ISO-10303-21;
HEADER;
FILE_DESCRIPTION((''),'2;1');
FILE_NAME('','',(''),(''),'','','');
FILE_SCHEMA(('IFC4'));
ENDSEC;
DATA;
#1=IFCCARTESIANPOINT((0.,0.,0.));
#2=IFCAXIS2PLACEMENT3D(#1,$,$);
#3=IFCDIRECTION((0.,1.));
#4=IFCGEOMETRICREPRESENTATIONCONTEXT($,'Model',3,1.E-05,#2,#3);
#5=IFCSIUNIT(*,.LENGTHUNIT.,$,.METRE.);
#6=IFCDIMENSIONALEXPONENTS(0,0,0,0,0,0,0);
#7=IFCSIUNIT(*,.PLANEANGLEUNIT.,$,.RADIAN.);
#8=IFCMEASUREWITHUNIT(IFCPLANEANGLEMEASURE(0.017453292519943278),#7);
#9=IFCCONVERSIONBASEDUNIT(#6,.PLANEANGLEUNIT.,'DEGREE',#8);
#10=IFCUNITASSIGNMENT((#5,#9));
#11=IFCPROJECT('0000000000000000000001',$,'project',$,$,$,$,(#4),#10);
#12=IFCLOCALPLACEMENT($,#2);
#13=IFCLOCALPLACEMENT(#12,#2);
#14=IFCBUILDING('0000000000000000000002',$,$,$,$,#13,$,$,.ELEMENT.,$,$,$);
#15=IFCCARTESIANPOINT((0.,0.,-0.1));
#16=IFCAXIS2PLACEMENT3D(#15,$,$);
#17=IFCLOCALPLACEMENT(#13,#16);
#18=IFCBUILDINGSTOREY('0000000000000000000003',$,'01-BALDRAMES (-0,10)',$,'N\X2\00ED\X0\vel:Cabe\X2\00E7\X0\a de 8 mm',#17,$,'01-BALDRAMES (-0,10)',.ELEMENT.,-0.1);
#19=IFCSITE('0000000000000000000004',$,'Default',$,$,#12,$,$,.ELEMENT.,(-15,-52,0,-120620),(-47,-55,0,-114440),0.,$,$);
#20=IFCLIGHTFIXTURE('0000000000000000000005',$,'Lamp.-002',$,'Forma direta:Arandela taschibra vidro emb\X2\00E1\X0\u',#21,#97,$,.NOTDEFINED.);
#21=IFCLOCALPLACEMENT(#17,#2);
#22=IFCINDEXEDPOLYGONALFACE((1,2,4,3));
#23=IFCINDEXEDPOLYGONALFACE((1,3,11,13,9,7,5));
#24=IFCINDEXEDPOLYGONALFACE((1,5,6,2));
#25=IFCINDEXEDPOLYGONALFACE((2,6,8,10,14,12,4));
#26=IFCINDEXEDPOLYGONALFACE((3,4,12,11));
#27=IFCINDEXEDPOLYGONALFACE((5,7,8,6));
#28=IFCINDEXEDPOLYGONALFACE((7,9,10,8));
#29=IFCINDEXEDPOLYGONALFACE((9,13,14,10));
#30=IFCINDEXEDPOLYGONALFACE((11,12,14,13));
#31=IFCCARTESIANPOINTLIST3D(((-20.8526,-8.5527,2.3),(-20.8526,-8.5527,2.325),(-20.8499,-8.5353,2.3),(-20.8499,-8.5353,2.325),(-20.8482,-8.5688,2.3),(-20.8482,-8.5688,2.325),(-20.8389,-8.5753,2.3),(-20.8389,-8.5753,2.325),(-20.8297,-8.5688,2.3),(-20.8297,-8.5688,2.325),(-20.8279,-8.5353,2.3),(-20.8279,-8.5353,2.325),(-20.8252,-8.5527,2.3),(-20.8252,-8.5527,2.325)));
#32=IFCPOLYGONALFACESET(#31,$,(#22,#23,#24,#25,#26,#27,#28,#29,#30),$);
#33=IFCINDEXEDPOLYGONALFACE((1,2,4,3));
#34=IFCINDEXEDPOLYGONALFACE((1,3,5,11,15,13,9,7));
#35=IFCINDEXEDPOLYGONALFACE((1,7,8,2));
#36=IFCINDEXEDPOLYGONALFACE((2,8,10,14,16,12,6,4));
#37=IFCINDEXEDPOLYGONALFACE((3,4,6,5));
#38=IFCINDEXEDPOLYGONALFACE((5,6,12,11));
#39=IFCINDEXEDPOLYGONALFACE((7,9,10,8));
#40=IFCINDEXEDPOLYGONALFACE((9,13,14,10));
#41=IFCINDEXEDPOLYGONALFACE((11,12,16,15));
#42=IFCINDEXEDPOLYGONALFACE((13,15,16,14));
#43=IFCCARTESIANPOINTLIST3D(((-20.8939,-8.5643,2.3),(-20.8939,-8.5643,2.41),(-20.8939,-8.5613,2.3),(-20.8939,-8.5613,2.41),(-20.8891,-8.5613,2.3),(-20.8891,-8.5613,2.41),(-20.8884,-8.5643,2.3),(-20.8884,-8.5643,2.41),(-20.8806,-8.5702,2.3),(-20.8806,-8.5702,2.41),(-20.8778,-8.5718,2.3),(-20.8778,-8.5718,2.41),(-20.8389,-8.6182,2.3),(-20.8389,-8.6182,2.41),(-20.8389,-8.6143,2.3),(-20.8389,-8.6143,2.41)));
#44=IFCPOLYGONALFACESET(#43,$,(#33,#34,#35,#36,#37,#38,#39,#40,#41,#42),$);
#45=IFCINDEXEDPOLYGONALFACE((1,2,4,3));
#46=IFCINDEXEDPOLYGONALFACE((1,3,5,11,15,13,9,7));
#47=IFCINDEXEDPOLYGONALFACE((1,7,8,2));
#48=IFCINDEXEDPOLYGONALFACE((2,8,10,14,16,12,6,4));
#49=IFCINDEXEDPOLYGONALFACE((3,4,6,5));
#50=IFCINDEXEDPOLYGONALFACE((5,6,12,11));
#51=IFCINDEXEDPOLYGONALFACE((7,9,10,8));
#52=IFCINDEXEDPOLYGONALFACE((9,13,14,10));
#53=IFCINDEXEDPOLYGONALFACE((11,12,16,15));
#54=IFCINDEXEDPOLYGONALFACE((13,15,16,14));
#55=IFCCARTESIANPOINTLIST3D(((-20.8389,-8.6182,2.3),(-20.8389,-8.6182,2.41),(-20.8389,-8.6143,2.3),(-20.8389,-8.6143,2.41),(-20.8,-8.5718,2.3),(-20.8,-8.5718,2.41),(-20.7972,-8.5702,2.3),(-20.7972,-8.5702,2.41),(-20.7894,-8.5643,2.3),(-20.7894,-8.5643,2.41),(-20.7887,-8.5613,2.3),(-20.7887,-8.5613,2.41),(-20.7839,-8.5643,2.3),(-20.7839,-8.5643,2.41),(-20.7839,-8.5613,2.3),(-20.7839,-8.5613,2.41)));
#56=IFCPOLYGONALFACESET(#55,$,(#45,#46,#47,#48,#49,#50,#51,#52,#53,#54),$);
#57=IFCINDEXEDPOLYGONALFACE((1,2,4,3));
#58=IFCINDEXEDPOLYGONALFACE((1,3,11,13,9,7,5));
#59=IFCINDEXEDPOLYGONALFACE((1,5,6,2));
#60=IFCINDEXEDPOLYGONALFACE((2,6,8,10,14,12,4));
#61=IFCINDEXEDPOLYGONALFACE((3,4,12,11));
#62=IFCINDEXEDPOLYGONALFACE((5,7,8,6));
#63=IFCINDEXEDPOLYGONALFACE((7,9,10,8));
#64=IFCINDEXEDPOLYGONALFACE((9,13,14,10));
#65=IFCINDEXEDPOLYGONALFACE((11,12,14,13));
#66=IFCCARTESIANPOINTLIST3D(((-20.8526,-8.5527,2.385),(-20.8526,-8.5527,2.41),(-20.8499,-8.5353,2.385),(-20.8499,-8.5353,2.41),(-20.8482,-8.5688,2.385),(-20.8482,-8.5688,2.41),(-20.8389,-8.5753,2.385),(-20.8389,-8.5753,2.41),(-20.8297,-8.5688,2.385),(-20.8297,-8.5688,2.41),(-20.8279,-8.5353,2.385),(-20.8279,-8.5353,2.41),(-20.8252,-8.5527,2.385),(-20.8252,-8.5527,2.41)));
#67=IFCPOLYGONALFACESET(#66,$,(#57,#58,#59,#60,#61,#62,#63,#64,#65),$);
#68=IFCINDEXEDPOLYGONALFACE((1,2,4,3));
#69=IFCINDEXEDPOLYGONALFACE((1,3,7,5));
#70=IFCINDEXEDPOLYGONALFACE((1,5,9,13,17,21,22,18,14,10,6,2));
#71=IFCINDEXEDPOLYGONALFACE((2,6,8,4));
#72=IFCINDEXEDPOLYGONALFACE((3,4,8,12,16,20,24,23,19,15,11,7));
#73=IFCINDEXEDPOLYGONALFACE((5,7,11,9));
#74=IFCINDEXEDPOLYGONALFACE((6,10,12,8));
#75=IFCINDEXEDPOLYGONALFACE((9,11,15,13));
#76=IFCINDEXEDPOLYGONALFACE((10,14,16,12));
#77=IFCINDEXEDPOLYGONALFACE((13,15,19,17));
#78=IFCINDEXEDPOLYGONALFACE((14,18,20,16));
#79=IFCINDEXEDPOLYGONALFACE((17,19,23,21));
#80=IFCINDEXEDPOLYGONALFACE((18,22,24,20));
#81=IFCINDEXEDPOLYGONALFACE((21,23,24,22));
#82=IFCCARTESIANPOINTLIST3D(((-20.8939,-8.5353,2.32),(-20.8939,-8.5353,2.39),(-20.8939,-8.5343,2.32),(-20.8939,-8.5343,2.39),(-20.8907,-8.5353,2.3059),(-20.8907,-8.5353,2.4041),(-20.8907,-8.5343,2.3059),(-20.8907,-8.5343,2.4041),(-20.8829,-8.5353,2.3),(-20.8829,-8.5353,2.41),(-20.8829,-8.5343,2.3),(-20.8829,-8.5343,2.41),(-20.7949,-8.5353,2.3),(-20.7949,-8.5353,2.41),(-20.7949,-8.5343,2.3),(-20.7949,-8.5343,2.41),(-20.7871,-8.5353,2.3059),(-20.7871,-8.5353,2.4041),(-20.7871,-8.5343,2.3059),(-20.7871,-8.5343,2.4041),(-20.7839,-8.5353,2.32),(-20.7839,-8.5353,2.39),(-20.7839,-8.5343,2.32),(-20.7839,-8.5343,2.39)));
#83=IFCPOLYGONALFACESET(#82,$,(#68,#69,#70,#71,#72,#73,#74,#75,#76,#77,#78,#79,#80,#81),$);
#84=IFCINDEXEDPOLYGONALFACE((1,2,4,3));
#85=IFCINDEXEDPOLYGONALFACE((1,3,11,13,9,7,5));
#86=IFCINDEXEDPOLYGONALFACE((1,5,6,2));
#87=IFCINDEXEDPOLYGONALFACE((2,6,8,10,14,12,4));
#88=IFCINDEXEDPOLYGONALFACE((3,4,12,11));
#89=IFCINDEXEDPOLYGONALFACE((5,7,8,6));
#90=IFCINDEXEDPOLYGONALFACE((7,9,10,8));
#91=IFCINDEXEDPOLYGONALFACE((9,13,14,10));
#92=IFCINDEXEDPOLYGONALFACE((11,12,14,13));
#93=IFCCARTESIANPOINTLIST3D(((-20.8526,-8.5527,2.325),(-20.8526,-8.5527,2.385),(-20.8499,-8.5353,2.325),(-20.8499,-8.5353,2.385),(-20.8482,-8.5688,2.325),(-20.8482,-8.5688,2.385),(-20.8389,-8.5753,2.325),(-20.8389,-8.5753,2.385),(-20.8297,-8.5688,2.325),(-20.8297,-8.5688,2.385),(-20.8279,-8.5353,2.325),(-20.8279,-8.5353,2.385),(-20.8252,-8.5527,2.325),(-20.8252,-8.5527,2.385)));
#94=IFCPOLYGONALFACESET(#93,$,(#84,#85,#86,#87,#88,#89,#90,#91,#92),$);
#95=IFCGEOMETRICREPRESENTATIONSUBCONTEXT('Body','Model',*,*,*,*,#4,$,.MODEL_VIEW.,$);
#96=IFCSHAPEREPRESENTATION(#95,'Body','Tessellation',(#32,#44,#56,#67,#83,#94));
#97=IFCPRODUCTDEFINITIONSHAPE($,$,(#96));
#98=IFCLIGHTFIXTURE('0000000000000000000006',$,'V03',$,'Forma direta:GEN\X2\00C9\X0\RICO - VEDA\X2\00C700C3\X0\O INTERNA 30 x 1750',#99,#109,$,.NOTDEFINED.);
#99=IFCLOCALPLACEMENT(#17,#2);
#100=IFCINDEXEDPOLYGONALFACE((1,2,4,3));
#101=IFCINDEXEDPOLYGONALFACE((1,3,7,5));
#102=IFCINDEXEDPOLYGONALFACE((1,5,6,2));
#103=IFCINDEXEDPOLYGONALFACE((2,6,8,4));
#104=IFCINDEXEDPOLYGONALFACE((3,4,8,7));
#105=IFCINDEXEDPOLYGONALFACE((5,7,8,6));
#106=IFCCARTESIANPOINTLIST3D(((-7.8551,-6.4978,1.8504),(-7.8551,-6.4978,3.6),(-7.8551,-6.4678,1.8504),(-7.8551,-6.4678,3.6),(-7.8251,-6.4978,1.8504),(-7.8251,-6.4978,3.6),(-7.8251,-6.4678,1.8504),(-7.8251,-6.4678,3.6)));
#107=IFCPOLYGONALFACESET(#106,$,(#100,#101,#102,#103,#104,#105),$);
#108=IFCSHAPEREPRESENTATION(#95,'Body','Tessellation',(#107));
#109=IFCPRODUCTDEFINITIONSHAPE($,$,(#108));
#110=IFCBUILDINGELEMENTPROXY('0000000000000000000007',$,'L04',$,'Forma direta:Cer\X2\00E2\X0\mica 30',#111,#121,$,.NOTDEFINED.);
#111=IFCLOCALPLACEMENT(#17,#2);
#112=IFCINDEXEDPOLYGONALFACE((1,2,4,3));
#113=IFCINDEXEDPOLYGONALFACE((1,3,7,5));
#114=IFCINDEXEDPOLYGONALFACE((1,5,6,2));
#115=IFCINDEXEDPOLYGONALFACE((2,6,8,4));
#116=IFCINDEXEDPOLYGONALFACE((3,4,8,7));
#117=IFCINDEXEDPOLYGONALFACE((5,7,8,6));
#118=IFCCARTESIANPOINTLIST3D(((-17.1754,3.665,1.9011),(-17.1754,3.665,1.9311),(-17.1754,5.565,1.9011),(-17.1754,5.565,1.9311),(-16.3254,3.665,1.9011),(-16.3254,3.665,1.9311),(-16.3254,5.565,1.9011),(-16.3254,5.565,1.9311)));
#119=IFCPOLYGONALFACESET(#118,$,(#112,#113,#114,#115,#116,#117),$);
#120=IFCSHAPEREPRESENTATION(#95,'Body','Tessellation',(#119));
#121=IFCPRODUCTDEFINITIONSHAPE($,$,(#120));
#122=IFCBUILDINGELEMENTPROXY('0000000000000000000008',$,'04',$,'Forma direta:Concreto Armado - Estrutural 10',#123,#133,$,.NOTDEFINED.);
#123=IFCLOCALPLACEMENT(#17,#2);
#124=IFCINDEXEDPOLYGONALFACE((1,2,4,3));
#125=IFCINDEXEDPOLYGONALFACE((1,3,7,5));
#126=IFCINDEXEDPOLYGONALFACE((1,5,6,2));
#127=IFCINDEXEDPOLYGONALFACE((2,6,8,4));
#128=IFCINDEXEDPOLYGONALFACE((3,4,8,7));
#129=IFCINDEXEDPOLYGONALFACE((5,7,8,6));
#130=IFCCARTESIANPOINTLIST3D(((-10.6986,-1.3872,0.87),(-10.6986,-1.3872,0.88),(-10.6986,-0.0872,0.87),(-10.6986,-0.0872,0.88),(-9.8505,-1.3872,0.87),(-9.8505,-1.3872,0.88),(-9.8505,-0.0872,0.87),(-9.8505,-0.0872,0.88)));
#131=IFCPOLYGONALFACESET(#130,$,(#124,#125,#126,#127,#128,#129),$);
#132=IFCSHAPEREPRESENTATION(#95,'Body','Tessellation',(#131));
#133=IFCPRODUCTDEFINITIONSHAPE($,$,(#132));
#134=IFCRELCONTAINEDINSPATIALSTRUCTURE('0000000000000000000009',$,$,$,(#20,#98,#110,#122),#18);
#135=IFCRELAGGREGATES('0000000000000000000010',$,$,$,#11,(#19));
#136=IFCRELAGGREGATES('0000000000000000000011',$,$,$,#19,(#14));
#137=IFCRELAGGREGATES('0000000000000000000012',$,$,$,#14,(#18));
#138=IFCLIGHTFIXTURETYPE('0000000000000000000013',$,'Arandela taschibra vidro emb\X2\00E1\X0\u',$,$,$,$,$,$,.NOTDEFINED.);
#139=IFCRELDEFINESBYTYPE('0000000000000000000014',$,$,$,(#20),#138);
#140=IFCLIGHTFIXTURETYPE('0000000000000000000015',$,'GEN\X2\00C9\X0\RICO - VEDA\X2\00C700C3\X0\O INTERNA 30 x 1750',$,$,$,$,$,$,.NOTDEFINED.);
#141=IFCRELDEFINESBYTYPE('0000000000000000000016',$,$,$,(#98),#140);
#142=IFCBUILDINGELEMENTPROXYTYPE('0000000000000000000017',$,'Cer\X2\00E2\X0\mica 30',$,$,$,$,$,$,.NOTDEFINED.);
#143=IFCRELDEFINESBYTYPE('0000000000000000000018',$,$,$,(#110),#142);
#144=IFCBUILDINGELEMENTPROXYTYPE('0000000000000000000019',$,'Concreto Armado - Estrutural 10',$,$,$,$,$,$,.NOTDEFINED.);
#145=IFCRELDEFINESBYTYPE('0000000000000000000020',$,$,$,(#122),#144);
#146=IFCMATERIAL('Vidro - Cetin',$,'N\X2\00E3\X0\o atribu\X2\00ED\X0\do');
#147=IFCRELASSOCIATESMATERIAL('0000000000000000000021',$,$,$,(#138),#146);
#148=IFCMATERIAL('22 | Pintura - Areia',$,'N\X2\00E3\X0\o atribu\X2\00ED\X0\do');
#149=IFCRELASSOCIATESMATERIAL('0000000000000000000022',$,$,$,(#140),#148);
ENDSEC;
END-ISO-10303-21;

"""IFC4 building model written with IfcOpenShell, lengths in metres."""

from ifc_helpers import new_model, entity, si_unit, converted_unit, direction, frame, origin, place, context, subcontext, project, spatial, indexed_curve, outline, extrude, material, type_object, element, save


model = new_model("IFC4")

# Units and contexts
model_context = context("Model", 3, precision=1e-05, world=origin(), true_north=direction((0.0, 1.0)))
body_context = subcontext(model_context, "Body", "Model", "MODEL_VIEW")
ifc_project = project(units=[si_unit("LENGTHUNIT", "METRE"), converted_unit("PLANEANGLEUNIT", "DEGREE", entity("IfcPlaneAngleMeasure", 0.017453292519943278), si_unit("PLANEANGLEUNIT", "RADIAN"), dimensions=[0, 0, 0, 0, 0, 0, 0])], contexts=[model_context])

# Site, building, storey
site_placement = place(None, origin())
site = spatial("IfcSite", under=ifc_project, at=site_placement, Name="Default", CompositionType="ELEMENT", RefLatitude=(-15, -52, 0, -120620), RefLongitude=(-47, -55, 0, -114440), RefElevation=0.0)
building_placement = place(site_placement, origin())
building = spatial("IfcBuilding", under=site, at=building_placement, CompositionType="ELEMENT")
storey_placement = place(building_placement, frame((0.0, 0.0, -0.1)))
storey = spatial("IfcBuildingStorey", under=building, at=storey_placement, Name="01-BALDRAMES (-0,10)", ObjectType="Nível:Cabeça de 8 mm", LongName="01-BALDRAMES (-0,10)", CompositionType="ELEMENT", Elevation=-0.1)

# Shared definitions
ifc_material_1 = material(Name="22 | Pintura - Areia", Category="Não atribuído")

# Light fixture
ifc_material_2 = material(Name="Vidro - Cetin", Category="Não atribuído")
light_fixture_type_1 = type_object("IfcLightFixtureType", Name="Arandela taschibra vidro embáu", PredefinedType="NOTDEFINED", material=ifc_material_2)
light_fixture_1_placement = place(storey_placement, origin())
element("IfcLightFixture", 1, at=light_fixture_1_placement, inside=storey, type_object=light_fixture_type_1, Name="Lamp.-002", ObjectType="Forma direta:Arandela taschibra vidro embáu", PredefinedType="NOTDEFINED", context=body_context, shape_type="SweptSolid", body=[
    extrude(outline(indexed_curve([(-0.0183, -0.014), (-0.0008, -0.014), (0.0145, -0.0071), (0.0195, 0.003), (0.0117, 0.0112), (-0.0049, 0.0131), (-0.0217, 0.0078), (-0.0183, -0.014)], self_intersect=False)), frame((-20.8389, -8.5556, 2.3), z_axis=(0.0, 0.0, 1.0), x_axis=(-0.153045, -0.988219, 0.0)), (0.0, 0.0, 1.0), 0.025),
    extrude(outline(indexed_curve([(-0.0169, -0.0187), (-0.0139, -0.0187), (-0.0139, -0.0132), (-0.008, -0.0054), (0.04, 0.0363), (0.0361, 0.0363), (-0.0065, -0.0026), (-0.0169, -0.0139), (-0.0169, -0.0187)], self_intersect=False)), frame((-20.8752, -8.5782, 2.3), z_axis=(0.0, 0.0, 1.0), x_axis=(-0.000013, -1.0, 0.0)), (0.0, 0.0, 1.0), 0.11),
    extrude(outline(indexed_curve([(-0.0187, -0.0169), (-0.0139, -0.0169), (-0.0026, -0.0065), (0.0363, 0.0361), (0.0363, 0.04), (-0.0054, -0.008), (-0.0132, -0.0139), (-0.0187, -0.0139), (-0.0187, -0.0169)], self_intersect=False)), frame((-20.8026, -8.5782, 2.3), z_axis=(0.0, 0.0, 1.0), x_axis=(-1.0, -0.000785, 0.0)), (0.0, 0.0, 1.0), 0.11),
    extrude(outline(indexed_curve([(-0.0183, -0.014), (-0.0008, -0.014), (0.0145, -0.0071), (0.0195, 0.003), (0.0117, 0.0112), (-0.0049, 0.0131), (-0.0217, 0.0078), (-0.0183, -0.014)], self_intersect=False)), frame((-20.8389, -8.5556, 2.385), z_axis=(0.0, 0.0, 1.0), x_axis=(-0.153045, -0.988219, 0.0)), (0.0, 0.0, 1.0), 0.025),
    extrude(outline(indexed_curve([(-0.044, -0.055), (0.044, -0.055), (0.0518, -0.0491), (0.055, -0.035), (0.055, 0.035), (0.0518, 0.0491), (0.044, 0.055), (-0.044, 0.055), (-0.0518, 0.0491), (-0.055, 0.035), (-0.055, -0.035), (-0.0518, -0.0491), (-0.044, -0.055)], self_intersect=False)), frame((-20.8389, -8.5353, 2.355), z_axis=(0.000013, 1.0, 0.0), x_axis=(-1.0, 0.000013, 0.0)), (0.0, 0.0, 1.0), 0.001),
    extrude(outline(indexed_curve([(-0.0183, -0.014), (-0.0008, -0.014), (0.0145, -0.0071), (0.0195, 0.003), (0.0117, 0.0112), (-0.0049, 0.0131), (-0.0217, 0.0078), (-0.0183, -0.014)], self_intersect=False)), frame((-20.8389, -8.5556, 2.325), z_axis=(0.0, 0.0, 1.0), x_axis=(-0.153045, -0.988219, 0.0)), (0.0, 0.0, 1.0), 0.06),
])

# Light fixture
light_fixture_type_2 = type_object("IfcLightFixtureType", Name="GENÉRICO - VEDAÇÃO INTERNA 30 x 1750", PredefinedType="NOTDEFINED", material=ifc_material_1)
light_fixture_2_placement = place(storey_placement, origin())
element("IfcLightFixture", 2, at=light_fixture_2_placement, inside=storey, type_object=light_fixture_type_2, Name="V03", ObjectType="Forma direta:GENÉRICO - VEDAÇÃO INTERNA 30 x 1750", PredefinedType="NOTDEFINED", context=body_context, shape_type="SweptSolid", body=[
    extrude(outline(indexed_curve([(-0.015, -0.015), (0.015, -0.015), (0.015, 0.015), (-0.015, 0.015), (-0.015, -0.015)], self_intersect=False)), frame((-7.8401, -6.4828, 1.8504)), (0.0, 0.0, 1.0), 1.7496),
])

# Building element proxies
building_element_proxy_type_1 = type_object("IfcBuildingElementProxyType", Name="Cerâmica 30", PredefinedType="NOTDEFINED")
proxy_1_placement = place(storey_placement, origin())
element("IfcBuildingElementProxy", 3, at=proxy_1_placement, inside=storey, type_object=building_element_proxy_type_1, Name="L04", ObjectType="Forma direta:Cerâmica 30", PredefinedType="NOTDEFINED", context=body_context, shape_type="SweptSolid", body=[
    extrude(outline(indexed_curve([(-0.95, -0.425), (0.95, -0.425), (0.95, 0.425), (-0.95, 0.425), (-0.95, -0.425)], self_intersect=False)), frame((-16.7504, 4.615, 1.9011), z_axis=(0.0, 0.0, 1.0), x_axis=(0.000013, 1.0, 0.0)), (0.0, 0.0, 1.0), 0.03),
])
building_element_proxy_type_2 = type_object("IfcBuildingElementProxyType", Name="Concreto Armado - Estrutural 10", PredefinedType="NOTDEFINED")
proxy_2_placement = place(storey_placement, origin())
element("IfcBuildingElementProxy", 4, at=proxy_2_placement, inside=storey, type_object=building_element_proxy_type_2, Name="04", ObjectType="Forma direta:Concreto Armado - Estrutural 10", PredefinedType="NOTDEFINED", context=body_context, shape_type="SweptSolid", body=[
    extrude(outline(indexed_curve([(-0.65, -0.4241), (0.65, -0.4241), (0.65, 0.4241), (-0.65, 0.4241), (-0.65, -0.4241)], self_intersect=False)), frame((-10.2745, -0.7372, 0.87), z_axis=(0.0, 0.0, 1.0), x_axis=(0.000013, 1.0, 0.0)), (0.0, 0.0, 1.0), 0.01),
])

save(model, "model.ifc")
